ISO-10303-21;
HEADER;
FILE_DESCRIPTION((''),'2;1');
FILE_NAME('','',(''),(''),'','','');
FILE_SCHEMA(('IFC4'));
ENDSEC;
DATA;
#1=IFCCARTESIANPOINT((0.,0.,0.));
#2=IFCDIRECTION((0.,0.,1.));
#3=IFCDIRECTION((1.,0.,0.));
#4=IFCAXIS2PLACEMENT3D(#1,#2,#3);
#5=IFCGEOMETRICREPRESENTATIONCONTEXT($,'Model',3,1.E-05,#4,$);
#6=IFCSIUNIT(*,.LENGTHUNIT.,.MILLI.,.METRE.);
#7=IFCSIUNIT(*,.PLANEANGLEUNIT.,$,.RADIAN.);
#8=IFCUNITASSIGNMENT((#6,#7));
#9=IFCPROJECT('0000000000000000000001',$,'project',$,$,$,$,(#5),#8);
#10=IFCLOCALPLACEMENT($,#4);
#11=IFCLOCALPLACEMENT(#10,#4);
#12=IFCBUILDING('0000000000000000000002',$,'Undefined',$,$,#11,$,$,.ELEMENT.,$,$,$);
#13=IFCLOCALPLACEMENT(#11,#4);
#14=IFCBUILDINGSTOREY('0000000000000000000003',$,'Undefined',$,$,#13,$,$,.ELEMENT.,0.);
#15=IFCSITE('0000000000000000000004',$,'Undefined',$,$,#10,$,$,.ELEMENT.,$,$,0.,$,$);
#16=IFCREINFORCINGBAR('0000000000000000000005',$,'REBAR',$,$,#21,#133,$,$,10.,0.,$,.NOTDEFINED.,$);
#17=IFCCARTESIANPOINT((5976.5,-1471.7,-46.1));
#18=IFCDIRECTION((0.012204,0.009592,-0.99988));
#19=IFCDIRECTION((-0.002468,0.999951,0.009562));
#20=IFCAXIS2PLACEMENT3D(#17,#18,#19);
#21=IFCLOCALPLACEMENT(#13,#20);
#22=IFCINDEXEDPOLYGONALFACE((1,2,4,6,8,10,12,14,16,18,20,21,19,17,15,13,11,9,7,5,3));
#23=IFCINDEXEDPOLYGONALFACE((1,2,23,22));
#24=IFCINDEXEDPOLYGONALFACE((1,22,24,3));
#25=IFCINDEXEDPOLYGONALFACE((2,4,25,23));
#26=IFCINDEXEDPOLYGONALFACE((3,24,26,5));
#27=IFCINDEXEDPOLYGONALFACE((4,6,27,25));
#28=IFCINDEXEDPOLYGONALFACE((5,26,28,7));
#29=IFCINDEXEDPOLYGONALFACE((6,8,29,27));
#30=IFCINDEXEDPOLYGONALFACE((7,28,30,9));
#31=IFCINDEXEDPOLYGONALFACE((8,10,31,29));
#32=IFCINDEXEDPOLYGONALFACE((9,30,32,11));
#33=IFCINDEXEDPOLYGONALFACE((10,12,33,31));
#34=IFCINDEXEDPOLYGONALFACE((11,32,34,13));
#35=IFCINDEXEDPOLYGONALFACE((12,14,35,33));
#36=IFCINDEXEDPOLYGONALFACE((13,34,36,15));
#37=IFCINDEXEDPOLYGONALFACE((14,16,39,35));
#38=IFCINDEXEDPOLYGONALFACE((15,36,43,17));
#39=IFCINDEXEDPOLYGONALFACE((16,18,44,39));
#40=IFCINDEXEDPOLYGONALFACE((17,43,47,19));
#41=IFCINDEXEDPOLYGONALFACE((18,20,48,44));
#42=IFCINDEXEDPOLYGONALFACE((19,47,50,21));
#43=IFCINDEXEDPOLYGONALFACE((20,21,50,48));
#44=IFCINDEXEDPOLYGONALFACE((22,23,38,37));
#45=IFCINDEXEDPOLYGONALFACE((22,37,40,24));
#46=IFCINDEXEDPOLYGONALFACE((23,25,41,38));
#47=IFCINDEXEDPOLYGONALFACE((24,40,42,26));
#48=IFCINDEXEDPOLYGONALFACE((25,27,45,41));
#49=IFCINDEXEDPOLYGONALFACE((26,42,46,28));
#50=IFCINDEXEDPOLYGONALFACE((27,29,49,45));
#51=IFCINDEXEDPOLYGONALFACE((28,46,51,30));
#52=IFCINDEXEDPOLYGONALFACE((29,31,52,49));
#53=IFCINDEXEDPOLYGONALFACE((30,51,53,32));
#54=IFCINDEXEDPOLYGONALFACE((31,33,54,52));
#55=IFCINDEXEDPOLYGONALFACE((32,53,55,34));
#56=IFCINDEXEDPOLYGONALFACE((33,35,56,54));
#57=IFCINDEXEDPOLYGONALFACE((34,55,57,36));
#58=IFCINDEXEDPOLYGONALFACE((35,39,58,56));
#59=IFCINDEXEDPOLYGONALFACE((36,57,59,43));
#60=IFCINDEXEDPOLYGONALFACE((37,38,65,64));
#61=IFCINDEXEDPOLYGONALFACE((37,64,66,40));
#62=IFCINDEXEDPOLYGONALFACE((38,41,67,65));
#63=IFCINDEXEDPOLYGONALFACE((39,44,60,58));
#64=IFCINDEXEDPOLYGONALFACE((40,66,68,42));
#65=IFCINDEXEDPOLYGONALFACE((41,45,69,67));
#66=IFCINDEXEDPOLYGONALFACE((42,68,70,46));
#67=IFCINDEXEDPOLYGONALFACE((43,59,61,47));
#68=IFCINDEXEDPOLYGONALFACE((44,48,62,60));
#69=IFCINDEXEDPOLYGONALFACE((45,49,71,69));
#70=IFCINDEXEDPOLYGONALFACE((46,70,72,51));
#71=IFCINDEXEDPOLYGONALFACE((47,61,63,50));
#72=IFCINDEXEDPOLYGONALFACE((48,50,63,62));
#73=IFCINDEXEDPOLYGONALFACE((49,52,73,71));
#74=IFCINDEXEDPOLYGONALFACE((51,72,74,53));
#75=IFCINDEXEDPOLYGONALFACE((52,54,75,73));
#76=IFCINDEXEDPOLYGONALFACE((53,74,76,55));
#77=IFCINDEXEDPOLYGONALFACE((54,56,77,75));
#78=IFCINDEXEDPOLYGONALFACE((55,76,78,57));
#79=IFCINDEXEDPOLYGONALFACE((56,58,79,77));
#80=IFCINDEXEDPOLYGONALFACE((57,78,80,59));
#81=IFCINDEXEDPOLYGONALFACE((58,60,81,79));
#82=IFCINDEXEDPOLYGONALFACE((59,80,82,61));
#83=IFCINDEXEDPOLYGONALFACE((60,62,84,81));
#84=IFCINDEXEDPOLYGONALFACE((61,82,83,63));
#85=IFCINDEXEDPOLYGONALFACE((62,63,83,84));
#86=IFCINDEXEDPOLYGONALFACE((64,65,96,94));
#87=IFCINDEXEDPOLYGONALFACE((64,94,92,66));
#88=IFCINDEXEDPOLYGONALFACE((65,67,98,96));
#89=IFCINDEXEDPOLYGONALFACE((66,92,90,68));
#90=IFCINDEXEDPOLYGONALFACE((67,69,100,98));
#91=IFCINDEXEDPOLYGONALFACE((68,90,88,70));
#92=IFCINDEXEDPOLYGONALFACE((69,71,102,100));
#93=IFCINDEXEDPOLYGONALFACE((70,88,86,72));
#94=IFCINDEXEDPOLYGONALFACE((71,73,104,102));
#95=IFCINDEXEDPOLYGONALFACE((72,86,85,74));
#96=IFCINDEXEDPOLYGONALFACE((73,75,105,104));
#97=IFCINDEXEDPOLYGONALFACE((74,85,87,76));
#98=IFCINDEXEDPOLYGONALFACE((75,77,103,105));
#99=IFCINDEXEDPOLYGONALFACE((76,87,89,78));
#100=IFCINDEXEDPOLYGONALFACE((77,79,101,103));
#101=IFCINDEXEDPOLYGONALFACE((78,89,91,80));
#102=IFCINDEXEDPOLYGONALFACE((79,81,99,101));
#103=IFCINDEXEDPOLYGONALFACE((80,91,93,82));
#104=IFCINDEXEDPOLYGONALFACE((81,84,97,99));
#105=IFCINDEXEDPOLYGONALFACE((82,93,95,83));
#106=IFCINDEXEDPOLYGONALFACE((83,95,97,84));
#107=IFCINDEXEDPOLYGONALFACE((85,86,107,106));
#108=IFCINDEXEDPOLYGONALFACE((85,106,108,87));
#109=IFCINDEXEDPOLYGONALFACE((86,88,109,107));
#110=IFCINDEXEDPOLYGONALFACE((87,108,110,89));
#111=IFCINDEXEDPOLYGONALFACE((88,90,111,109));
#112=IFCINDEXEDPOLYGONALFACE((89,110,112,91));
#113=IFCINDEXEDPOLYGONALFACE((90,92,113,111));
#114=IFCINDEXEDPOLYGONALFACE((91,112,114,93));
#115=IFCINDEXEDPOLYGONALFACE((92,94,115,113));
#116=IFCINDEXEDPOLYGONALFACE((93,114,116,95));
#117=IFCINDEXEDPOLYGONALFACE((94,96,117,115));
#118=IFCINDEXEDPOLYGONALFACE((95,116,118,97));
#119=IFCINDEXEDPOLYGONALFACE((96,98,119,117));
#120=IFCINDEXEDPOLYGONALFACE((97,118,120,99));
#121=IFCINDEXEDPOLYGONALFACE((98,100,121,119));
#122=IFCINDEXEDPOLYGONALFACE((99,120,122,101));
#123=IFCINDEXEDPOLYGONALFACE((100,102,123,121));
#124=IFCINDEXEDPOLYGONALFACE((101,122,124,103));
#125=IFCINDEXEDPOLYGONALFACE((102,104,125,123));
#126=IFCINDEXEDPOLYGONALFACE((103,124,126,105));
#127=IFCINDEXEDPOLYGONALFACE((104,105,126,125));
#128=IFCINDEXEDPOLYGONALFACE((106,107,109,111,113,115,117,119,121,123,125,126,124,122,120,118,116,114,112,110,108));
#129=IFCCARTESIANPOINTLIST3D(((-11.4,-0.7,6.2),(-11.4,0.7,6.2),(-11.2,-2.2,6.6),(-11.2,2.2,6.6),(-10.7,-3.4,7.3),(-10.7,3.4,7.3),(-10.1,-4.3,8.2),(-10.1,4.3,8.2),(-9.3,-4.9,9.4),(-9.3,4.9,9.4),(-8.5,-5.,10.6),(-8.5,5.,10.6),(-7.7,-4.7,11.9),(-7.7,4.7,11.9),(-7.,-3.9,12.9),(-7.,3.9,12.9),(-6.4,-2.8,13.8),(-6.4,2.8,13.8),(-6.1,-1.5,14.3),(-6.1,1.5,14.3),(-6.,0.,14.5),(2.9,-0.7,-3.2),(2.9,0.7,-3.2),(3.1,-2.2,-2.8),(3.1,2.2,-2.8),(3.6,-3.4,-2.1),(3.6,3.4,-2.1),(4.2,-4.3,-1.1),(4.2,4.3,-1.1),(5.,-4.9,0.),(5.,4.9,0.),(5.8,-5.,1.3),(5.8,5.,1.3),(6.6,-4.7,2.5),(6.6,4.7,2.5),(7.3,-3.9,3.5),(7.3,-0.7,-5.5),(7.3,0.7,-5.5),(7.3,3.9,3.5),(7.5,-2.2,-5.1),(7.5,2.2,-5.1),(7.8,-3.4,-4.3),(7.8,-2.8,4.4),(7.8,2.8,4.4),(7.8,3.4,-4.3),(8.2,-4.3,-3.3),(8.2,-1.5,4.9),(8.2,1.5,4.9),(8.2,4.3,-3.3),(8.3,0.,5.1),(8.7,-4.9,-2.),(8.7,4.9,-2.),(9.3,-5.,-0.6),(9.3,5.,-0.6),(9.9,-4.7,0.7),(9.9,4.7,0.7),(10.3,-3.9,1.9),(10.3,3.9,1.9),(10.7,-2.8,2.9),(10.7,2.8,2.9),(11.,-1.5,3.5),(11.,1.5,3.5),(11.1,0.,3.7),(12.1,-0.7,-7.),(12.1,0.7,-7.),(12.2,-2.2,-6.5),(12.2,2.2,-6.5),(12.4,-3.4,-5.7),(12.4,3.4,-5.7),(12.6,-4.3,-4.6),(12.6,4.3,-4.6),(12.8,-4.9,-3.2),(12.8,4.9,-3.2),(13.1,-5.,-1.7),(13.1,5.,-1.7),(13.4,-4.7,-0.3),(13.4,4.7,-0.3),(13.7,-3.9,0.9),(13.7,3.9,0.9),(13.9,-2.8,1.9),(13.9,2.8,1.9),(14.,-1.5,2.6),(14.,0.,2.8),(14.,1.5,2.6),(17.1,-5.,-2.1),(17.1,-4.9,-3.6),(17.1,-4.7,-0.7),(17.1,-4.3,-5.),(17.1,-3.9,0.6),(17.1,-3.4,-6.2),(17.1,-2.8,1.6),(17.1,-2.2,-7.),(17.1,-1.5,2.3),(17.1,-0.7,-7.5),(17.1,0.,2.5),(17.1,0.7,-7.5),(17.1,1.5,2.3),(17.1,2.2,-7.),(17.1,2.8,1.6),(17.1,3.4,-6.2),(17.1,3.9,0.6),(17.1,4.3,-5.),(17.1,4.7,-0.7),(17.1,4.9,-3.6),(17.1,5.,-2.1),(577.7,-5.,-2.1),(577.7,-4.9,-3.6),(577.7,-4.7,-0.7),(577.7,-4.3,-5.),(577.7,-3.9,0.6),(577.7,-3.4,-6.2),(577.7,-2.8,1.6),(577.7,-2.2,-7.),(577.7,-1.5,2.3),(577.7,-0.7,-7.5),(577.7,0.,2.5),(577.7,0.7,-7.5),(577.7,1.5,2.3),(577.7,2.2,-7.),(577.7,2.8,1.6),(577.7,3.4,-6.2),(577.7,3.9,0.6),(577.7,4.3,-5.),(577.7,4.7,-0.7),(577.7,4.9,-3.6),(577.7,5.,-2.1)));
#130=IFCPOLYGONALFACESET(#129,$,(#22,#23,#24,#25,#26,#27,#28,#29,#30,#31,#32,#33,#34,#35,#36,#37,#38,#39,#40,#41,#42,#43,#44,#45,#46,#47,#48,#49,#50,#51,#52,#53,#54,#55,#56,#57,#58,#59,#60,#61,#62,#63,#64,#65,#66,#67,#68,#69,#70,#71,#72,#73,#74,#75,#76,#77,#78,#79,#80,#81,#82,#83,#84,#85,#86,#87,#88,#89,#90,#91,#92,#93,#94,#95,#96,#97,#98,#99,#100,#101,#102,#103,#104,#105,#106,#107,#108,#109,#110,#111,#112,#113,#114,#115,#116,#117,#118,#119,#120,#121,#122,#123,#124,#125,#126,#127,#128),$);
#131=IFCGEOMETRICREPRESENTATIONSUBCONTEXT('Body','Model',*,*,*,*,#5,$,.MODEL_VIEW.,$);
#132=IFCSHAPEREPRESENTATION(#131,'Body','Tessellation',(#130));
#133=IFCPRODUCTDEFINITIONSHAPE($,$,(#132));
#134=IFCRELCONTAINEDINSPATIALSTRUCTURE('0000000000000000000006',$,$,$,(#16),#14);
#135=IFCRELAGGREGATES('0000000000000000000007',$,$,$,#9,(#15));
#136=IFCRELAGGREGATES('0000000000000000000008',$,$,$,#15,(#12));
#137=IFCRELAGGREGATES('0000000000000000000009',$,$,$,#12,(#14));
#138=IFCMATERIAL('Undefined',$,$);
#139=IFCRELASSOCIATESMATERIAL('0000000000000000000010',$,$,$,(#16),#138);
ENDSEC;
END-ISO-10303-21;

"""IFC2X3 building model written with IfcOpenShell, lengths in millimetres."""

from ifc_helpers import new_model, entity, si_unit, frame, origin_with_axes, place, context, subcontext, project, spatial, source, transform, mapped, material, element, save


model = new_model("IFC2X3")

# Units and contexts
model_context = context("Model", 3, precision=1e-05, world=origin_with_axes())
body_context = subcontext(model_context, "Body", "Model", "MODEL_VIEW")
ifc_project = project(units=[si_unit("LENGTHUNIT", "METRE", prefix="MILLI"), si_unit("PLANEANGLEUNIT", "RADIAN")], contexts=[model_context])

# Site, building, storey
site_placement = place(None, origin_with_axes())
site = spatial("IfcSite", under=ifc_project, at=site_placement, Name="Undefined", CompositionType="ELEMENT", RefElevation=0.0)
building_placement = place(site_placement, origin_with_axes())
building = spatial("IfcBuilding", under=site, at=building_placement, Name="Undefined", CompositionType="ELEMENT")
storey_placement = place(building_placement, origin_with_axes())
storey = spatial("IfcBuildingStorey", under=building, at=storey_placement, Name="Undefined", CompositionType="ELEMENT", Elevation=0.0)

# Reinforcing bar
ifc_material_1 = material(Name="Undefined")
shared_shape_1 = source(origin_with_axes(), body_context, "Body", "AdvancedSweptSolid", [
    entity("IfcSweptDiskSolid", entity("IfcCompositeCurve", [entity("IfcCompositeCurveSegment", "CONTINUOUS", True, entity("IfcTrimmedCurve", entity("IfcLine", entity("IfcCartesianPoint", [0.0, 0.0, 0.0]), entity("IfcVector", entity("IfcDirection", [0.835483, 0.0, -0.549516]), 1.0)), [entity("IfcParameterValue", 0.0)], [entity("IfcParameterValue", 17.082101)], True, "PARAMETER")), entity("IfcCompositeCurveSegment", "CONTINUOUS", True, entity("IfcTrimmedCurve", entity("IfcCircle", entity("IfcAxis2Placement3D", entity("IfcCartesianPoint", [25.8, 0.0, 8.2]), entity("IfcDirection", [0.0, -1.0, 0.0]), entity("IfcDirection", [-0.549516, 0.0, -0.835483])), 21.0), [entity("IfcParameterValue", 0.0)], [entity("IfcParameterValue", 0.581785)], True, "PARAMETER")), entity("IfcCompositeCurveSegment", "DISCONTINUOUS", True, entity("IfcTrimmedCurve", entity("IfcLine", entity("IfcCartesianPoint", [25.8, 0.0, -12.8]), entity("IfcVector", entity("IfcDirection", [1.0, 0.0, 0.0]), 1.0)), [entity("IfcParameterValue", 0.0)], [entity("IfcParameterValue", 560.593055)], True, "PARAMETER"))], False), 5.0, None, 0.0, 578.3),
])
reinforcing_bar_1_placement = place(storey_placement, frame((5976.5, -1471.7, -46.1), z_axis=(0.012204, 0.009592, -0.99988), x_axis=(-0.002468, 0.999951, 0.009562)))
element("IfcReinforcingBar", 1, at=reinforcing_bar_1_placement, inside=storey, material=ifc_material_1, Name="REBAR", BarRole="NOTDEFINED", CrossSectionArea=0.0, NominalDiameter=10.0, context=body_context, shape_type="MappedRepresentation", body=[
    mapped(shared_shape_1, transform((-8.7, 0.0, 10.3))),
])

save(model, "model.ifc")
